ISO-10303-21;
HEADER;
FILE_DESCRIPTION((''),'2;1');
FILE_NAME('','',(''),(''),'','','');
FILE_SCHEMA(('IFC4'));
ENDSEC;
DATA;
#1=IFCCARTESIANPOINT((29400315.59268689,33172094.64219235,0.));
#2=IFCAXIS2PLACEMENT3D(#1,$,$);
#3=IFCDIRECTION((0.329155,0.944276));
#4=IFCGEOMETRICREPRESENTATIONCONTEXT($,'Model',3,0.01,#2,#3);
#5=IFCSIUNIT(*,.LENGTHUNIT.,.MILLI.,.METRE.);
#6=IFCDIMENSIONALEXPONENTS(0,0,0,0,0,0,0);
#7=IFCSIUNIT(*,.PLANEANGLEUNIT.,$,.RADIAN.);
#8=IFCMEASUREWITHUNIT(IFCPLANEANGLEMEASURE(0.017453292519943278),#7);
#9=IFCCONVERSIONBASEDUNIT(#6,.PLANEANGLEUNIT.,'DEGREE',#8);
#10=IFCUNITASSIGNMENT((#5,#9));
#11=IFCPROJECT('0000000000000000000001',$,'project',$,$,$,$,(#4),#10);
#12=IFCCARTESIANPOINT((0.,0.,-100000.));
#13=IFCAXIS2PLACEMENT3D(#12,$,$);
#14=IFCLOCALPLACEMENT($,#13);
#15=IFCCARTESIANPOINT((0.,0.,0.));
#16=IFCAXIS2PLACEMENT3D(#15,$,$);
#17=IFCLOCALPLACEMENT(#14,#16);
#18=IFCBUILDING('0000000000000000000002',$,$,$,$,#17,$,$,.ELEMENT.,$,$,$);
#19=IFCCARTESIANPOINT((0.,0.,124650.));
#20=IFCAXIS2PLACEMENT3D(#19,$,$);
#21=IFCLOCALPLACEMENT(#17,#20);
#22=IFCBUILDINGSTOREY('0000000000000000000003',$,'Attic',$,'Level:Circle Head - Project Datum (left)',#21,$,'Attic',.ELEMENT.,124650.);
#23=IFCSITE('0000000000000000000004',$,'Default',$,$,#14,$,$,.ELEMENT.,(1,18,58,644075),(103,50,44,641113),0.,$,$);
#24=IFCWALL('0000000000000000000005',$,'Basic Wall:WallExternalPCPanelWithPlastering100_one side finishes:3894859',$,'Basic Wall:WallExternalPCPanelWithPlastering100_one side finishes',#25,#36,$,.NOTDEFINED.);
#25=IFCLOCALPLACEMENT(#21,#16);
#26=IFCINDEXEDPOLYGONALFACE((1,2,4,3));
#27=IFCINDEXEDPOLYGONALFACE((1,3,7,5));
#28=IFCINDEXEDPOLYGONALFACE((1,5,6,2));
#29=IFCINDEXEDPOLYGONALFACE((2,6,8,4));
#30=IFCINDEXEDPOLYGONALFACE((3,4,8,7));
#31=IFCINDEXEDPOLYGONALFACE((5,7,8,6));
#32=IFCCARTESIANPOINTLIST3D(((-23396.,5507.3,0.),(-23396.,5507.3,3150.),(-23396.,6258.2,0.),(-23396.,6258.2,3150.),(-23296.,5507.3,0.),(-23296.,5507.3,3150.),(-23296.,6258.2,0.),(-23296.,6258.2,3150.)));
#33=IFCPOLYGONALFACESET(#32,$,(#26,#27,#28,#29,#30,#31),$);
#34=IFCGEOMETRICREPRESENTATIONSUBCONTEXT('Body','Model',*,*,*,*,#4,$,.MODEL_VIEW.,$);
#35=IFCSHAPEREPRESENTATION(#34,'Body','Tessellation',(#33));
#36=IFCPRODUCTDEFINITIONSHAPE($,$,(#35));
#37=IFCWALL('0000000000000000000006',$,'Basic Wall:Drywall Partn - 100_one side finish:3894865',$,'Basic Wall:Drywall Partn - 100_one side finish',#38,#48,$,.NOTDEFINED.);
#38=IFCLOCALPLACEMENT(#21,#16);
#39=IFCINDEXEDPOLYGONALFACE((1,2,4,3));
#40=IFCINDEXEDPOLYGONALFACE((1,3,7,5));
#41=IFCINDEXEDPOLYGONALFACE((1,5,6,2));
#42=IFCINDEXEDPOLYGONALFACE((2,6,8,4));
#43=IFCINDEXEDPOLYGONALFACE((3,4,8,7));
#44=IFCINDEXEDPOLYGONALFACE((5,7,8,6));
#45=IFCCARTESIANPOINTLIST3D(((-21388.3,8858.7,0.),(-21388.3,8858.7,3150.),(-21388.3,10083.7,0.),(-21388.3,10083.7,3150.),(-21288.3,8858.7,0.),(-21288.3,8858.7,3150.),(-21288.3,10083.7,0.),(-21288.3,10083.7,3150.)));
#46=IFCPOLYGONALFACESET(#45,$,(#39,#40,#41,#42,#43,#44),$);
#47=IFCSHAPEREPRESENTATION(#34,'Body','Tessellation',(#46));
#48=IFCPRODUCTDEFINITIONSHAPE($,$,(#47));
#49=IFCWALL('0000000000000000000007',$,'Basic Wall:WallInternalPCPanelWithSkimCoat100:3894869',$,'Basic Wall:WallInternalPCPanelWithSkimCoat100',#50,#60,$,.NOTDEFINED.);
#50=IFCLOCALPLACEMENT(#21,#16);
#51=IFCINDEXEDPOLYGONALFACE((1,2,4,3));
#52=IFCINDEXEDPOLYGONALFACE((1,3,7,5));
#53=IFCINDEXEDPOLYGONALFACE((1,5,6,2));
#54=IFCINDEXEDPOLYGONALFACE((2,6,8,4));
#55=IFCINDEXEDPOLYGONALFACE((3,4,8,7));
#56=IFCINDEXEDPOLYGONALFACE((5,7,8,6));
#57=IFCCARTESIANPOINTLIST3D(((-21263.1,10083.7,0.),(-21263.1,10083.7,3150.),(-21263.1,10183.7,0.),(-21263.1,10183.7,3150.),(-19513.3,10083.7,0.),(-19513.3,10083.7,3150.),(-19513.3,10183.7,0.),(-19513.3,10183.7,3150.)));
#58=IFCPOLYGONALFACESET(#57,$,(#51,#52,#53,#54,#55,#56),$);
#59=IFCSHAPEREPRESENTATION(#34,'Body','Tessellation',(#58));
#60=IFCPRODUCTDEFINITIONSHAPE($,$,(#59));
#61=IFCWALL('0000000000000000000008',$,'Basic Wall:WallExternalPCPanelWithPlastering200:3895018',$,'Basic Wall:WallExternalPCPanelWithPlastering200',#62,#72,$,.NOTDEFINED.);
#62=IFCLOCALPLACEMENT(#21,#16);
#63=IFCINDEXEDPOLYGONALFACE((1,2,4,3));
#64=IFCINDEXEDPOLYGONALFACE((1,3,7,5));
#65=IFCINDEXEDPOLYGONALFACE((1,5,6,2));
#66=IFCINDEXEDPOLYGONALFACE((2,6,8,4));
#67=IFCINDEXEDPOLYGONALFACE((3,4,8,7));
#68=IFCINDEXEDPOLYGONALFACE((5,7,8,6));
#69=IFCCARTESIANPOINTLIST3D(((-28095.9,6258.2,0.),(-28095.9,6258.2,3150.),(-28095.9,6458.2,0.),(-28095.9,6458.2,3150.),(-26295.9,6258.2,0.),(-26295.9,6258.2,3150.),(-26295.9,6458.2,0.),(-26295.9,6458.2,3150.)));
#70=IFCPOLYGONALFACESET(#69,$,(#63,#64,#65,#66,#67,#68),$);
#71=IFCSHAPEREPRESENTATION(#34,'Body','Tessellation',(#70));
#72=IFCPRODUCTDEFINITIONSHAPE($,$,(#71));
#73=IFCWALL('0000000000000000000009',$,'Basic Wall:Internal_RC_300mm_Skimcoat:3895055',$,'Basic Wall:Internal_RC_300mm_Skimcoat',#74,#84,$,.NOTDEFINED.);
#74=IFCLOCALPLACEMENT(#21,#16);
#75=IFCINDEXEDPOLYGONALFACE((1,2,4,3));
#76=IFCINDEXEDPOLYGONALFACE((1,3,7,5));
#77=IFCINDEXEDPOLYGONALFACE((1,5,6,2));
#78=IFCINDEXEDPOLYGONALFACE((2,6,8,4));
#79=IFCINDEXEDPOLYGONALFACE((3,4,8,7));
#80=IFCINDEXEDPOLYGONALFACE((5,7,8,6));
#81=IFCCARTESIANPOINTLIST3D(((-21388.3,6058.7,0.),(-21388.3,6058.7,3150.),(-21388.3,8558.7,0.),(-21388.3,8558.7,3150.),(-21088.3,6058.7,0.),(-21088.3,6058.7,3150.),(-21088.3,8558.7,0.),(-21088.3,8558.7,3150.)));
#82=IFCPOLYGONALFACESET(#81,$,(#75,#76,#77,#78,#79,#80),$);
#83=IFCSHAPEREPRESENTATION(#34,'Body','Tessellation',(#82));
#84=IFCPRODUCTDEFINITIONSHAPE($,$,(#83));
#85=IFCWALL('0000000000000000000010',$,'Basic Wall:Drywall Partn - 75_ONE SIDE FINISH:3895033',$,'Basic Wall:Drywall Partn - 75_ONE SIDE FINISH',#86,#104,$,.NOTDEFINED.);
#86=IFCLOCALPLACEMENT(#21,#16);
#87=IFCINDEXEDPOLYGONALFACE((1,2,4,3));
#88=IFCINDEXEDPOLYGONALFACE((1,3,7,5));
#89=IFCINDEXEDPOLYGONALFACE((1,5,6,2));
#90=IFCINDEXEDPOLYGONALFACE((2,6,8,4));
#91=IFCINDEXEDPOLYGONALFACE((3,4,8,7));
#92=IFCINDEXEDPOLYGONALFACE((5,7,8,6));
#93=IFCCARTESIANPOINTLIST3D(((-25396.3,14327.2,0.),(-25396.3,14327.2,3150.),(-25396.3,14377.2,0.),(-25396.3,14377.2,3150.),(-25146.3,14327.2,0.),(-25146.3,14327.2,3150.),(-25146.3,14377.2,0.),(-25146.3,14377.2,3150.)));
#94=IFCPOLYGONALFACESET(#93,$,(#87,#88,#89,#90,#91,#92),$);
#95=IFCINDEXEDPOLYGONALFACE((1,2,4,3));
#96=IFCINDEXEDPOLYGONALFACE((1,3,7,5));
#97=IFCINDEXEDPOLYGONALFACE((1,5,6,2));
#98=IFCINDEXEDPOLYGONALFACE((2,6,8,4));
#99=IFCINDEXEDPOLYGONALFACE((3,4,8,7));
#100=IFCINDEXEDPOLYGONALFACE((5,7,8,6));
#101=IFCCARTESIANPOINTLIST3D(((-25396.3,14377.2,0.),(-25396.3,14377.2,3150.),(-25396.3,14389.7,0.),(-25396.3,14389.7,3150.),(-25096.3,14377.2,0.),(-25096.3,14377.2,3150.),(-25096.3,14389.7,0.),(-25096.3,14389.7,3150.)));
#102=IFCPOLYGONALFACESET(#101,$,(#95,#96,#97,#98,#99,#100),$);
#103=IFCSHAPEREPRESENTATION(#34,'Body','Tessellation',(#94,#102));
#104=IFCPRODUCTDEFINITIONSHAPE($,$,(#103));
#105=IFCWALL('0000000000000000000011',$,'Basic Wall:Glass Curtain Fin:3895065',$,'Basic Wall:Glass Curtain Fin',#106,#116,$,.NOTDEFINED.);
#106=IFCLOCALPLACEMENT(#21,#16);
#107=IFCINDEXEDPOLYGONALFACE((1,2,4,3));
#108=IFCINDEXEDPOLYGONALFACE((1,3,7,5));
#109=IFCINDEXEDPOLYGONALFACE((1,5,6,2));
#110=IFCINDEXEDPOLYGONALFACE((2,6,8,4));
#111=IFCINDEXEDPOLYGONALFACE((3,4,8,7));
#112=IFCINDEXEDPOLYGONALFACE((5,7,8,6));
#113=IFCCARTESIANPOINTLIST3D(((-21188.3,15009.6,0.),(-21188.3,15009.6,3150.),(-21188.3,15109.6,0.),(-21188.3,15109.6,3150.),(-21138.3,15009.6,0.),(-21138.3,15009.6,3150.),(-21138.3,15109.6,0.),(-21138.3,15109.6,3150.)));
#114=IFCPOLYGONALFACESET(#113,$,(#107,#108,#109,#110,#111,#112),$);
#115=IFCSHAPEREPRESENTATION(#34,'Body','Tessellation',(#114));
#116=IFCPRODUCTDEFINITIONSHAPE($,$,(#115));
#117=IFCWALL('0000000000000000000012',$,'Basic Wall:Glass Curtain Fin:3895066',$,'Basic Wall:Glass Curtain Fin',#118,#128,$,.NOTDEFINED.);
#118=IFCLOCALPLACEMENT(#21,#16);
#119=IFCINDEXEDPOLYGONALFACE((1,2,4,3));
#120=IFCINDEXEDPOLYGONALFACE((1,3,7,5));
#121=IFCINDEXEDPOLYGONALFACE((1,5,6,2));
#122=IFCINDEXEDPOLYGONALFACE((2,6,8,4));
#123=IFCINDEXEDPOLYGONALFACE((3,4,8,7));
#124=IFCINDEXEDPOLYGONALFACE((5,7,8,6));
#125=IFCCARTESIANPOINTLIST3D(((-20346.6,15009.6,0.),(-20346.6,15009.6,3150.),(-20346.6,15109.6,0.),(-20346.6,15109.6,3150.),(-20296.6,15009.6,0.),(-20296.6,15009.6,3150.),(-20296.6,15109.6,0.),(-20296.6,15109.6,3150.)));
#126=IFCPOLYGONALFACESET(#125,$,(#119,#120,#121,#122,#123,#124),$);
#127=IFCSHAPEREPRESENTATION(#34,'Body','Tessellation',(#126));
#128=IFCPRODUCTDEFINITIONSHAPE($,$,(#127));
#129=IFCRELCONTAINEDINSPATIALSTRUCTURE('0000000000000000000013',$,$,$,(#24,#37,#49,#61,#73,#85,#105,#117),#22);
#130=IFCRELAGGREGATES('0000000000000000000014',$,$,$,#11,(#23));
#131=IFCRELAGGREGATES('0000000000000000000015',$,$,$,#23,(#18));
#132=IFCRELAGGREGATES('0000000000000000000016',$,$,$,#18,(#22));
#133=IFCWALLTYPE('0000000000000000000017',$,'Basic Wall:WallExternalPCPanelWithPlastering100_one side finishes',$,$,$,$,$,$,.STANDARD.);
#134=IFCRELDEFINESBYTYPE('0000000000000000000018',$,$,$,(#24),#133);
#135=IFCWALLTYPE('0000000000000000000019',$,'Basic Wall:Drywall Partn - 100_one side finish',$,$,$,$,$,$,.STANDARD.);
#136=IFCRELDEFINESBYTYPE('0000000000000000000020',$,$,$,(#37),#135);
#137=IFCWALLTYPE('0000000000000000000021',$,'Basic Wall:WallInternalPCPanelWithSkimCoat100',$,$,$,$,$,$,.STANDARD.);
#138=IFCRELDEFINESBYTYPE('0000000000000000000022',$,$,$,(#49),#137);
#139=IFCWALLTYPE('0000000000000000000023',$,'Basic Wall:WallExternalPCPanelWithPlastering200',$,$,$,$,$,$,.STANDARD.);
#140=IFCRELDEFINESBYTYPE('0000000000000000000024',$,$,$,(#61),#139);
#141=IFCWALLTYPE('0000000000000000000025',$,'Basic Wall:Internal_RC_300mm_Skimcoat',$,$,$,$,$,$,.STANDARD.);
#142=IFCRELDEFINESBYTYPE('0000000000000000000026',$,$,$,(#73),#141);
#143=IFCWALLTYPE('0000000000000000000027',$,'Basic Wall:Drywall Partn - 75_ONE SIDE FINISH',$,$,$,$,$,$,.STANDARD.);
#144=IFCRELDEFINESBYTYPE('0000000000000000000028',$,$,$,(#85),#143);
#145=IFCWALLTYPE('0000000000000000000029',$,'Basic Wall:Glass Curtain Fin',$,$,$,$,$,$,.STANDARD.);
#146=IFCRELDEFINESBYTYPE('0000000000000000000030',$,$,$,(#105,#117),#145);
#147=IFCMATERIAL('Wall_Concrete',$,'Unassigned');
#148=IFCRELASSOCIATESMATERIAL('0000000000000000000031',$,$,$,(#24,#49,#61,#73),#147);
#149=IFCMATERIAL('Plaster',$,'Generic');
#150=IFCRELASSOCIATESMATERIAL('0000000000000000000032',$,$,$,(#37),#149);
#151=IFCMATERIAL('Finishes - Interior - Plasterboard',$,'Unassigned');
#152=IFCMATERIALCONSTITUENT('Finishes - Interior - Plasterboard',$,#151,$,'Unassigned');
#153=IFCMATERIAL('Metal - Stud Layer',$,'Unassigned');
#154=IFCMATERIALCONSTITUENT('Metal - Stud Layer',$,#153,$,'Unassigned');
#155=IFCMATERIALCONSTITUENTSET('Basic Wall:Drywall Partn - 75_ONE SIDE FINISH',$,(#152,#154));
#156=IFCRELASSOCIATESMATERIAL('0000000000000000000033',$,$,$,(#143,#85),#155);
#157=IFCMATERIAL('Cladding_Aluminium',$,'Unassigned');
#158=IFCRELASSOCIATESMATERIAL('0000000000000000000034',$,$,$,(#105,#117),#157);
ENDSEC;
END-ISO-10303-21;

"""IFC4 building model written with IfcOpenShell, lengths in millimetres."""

from ifc_helpers import new_model, entity, si_unit, converted_unit, direction, frame, origin, place, context, subcontext, project, spatial, indexed_curve, outline, extrude, material, constituent, constituent_set, type_object, element, save


model = new_model("IFC4")

# Units and contexts
model_context = context("Model", 3, precision=0.01, world=frame((29400315.59268689, 33172094.64219235, 0.0)), true_north=direction((0.329155, 0.944276)))
body_context = subcontext(model_context, "Body", "Model", "MODEL_VIEW")
ifc_project = project(units=[si_unit("LENGTHUNIT", "METRE", prefix="MILLI"), converted_unit("PLANEANGLEUNIT", "DEGREE", entity("IfcPlaneAngleMeasure", 0.017453292519943278), si_unit("PLANEANGLEUNIT", "RADIAN"), dimensions=[0, 0, 0, 0, 0, 0, 0])], contexts=[model_context])

# Site, building, storey
site_placement = place(None, frame((0.0, 0.0, -100000.0)))
site = spatial("IfcSite", under=ifc_project, at=site_placement, Name="Default", CompositionType="ELEMENT", RefLatitude=(1, 18, 58, 644075), RefLongitude=(103, 50, 44, 641113), RefElevation=0.0)
building_placement = place(site_placement, origin())
building = spatial("IfcBuilding", under=site, at=building_placement, CompositionType="ELEMENT")
storey_placement = place(building_placement, frame((0.0, 0.0, 124650.0)))
storey = spatial("IfcBuildingStorey", under=building, at=storey_placement, Name="Attic", ObjectType="Level:Circle Head - Project Datum (left)", LongName="Attic", CompositionType="ELEMENT", Elevation=124650.0)

# Walls
ifc_material_1 = material(Name="Metal - Stud Layer", Category="Unassigned")
ifc_material_2 = material(Name="Wall_Concrete", Category="Unassigned")
wall_type_1 = type_object("IfcWallType", Name="Basic Wall:WallExternalPCPanelWithPlastering100_one side finishes", PredefinedType="STANDARD")
wall_1_placement = place(storey_placement, frame((-23346.0, 6258.2, 0.0), z_axis=(0.0, 0.0, 1.0), x_axis=(0.0, -1.0, 0.0)))
element("IfcWall", 1, at=wall_1_placement, inside=storey, type_object=wall_type_1, material=ifc_material_2, Name="Basic Wall:WallExternalPCPanelWithPlastering100_one side finishes:3894859", ObjectType="Basic Wall:WallExternalPCPanelWithPlastering100_one side finishes", PredefinedType="NOTDEFINED", context=body_context, shape_type="SweptSolid", body=[
    extrude(outline(indexed_curve([(751.0, 50.0), (0.0, 50.0), (0.0, -50.0), (751.0, -50.0), (751.0, 50.0)], self_intersect=False)), origin(), (0.0, 0.0, 1.0), 3150.0),
])
ifc_material_3 = material(Name="Plaster", Category="Generic")
wall_type_2 = type_object("IfcWallType", Name="Basic Wall:Drywall Partn - 100_one side finish", PredefinedType="STANDARD")
wall_2_placement = place(storey_placement, frame((-21338.3, 8858.7, 0.0), z_axis=(0.0, 0.0, 1.0), x_axis=(0.0, 1.0, 0.0)))
element("IfcWall", 2, at=wall_2_placement, inside=storey, type_object=wall_type_2, material=ifc_material_3, Name="Basic Wall:Drywall Partn - 100_one side finish:3894865", ObjectType="Basic Wall:Drywall Partn - 100_one side finish", PredefinedType="NOTDEFINED", context=body_context, shape_type="SweptSolid", body=[
    extrude(outline(indexed_curve([(1225.0, 50.0), (0.0, 50.0), (0.0, -50.0), (1225.0, -50.0), (1225.0, 50.0)], self_intersect=False)), origin(), (0.0, 0.0, 1.0), 3150.0),
])
wall_type_3 = type_object("IfcWallType", Name="Basic Wall:WallInternalPCPanelWithSkimCoat100", PredefinedType="STANDARD")
wall_3_placement = place(storey_placement, frame((-19513.3, 10133.7, 0.0), z_axis=(0.0, 0.0, 1.0), x_axis=(-1.0, 0.0, 0.0)))
element("IfcWall", 3, at=wall_3_placement, inside=storey, type_object=wall_type_3, material=ifc_material_2, Name="Basic Wall:WallInternalPCPanelWithSkimCoat100:3894869", ObjectType="Basic Wall:WallInternalPCPanelWithSkimCoat100", PredefinedType="NOTDEFINED", context=body_context, shape_type="SweptSolid", body=[
    extrude(outline(indexed_curve([(1749.7, 50.0), (0.0, 50.0), (0.0, -50.0), (1749.7, -50.0), (1749.7, 50.0)], self_intersect=False)), origin(), (0.0, 0.0, 1.0), 3150.0),
])
wall_type_4 = type_object("IfcWallType", Name="Basic Wall:WallExternalPCPanelWithPlastering200", PredefinedType="STANDARD")
wall_4_placement = place(storey_placement, frame((-26295.9, 6358.2, 0.0), z_axis=(0.0, 0.0, 1.0), x_axis=(-1.0, 0.0, 0.0)))
element("IfcWall", 4, at=wall_4_placement, inside=storey, type_object=wall_type_4, material=ifc_material_2, Name="Basic Wall:WallExternalPCPanelWithPlastering200:3895018", ObjectType="Basic Wall:WallExternalPCPanelWithPlastering200", PredefinedType="NOTDEFINED", context=body_context, shape_type="SweptSolid", body=[
    extrude(outline(indexed_curve([(1800.0, 100.0), (0.0, 100.0), (0.0, -100.0), (1800.0, -100.0), (1800.0, 100.0)], self_intersect=False)), origin(), (0.0, 0.0, 1.0), 3150.0),
])
wall_type_5 = type_object("IfcWallType", Name="Basic Wall:Internal_RC_300mm_Skimcoat", PredefinedType="STANDARD")
wall_5_placement = place(storey_placement, frame((-21238.3, 8558.7, 0.0), z_axis=(0.0, 0.0, 1.0), x_axis=(0.0, -1.0, 0.0)))
element("IfcWall", 5, at=wall_5_placement, inside=storey, type_object=wall_type_5, material=ifc_material_2, Name="Basic Wall:Internal_RC_300mm_Skimcoat:3895055", ObjectType="Basic Wall:Internal_RC_300mm_Skimcoat", PredefinedType="NOTDEFINED", context=body_context, shape_type="SweptSolid", body=[
    extrude(outline(indexed_curve([(2500.0, 150.0), (0.0, 150.0), (0.0, -150.0), (2500.0, -150.0), (2500.0, 150.0)], self_intersect=False)), origin(), (0.0, 0.0, 1.0), 3150.0),
])
ifc_material_4 = material(Name="Finishes - Interior - Plasterboard", Category="Unassigned")
ifc_constituent_1 = constituent(ifc_material_4, Name="Finishes - Interior - Plasterboard", Category="Unassigned")
ifc_constituent_2 = constituent(ifc_material_1, Name="Metal - Stud Layer", Category="Unassigned")
ifc_constituent_set = constituent_set(constituents=[ifc_constituent_1, ifc_constituent_2], Name="Basic Wall:Drywall Partn - 75_ONE SIDE FINISH")
wall_type_6 = type_object("IfcWallType", Name="Basic Wall:Drywall Partn - 75_ONE SIDE FINISH", PredefinedType="STANDARD", material=ifc_constituent_set)
wall_6_placement = place(storey_placement, frame((-25146.3, 14358.4, 0.0), z_axis=(0.0, 0.0, 1.0), x_axis=(-1.0, 0.0, 0.0)))
element("IfcWall", 6, at=wall_6_placement, inside=storey, type_object=wall_type_6, material=ifc_constituent_set, Name="Basic Wall:Drywall Partn - 75_ONE SIDE FINISH:3895033", ObjectType="Basic Wall:Drywall Partn - 75_ONE SIDE FINISH", PredefinedType="NOTDEFINED", context=body_context, shape_type="SweptSolid", body=[
    extrude(outline(indexed_curve([(-25.0, -125.0), (25.0, -125.0), (25.0, 125.0), (-25.0, 125.0), (-25.0, -125.0)], self_intersect=False)), frame((125.0, 6.3, 0.0), z_axis=(0.0, 0.0, 1.0), x_axis=(0.0, -1.0, 0.0)), (0.0, 0.0, 1.0), 3150.0),
    extrude(outline(indexed_curve([(-6.3, -150.0), (6.3, -150.0), (6.3, 150.0), (-6.3, 150.0), (-6.3, -150.0)], self_intersect=False)), frame((100.0, -25.0, 0.0), z_axis=(0.0, 0.0, 1.0), x_axis=(0.0, 1.0, 0.0)), (0.0, 0.0, 1.0), 3150.0),
])
ifc_material_5 = material(Name="Cladding_Aluminium", Category="Unassigned")
wall_type_7 = type_object("IfcWallType", Name="Basic Wall:Glass Curtain Fin", PredefinedType="STANDARD")
for number, where, z_axis, x_axis, name in (
    (7, (-21163.3, 15009.6, 0.0), (0.0, 0.0, 1.0), (0.0, 1.0, 0.0), "Basic Wall:Glass Curtain Fin:3895065"),
    (8, (-20321.6, 15009.6, 0.0), (0.0, 0.0, 1.0), (0.0, 1.0, 0.0), "Basic Wall:Glass Curtain Fin:3895066"),
):
    element("IfcWall", number, at=place(storey_placement, frame(where, z_axis=z_axis, x_axis=x_axis)), inside=storey, type_object=wall_type_7, material=ifc_material_5, Name=name, ObjectType="Basic Wall:Glass Curtain Fin", PredefinedType="NOTDEFINED", context=body_context, shape_type="SweptSolid", body=[
        extrude(outline(indexed_curve([(100.0, 25.0), (0.0, 25.0), (0.0, -25.0), (100.0, -25.0), (100.0, 25.0)], self_intersect=False)), origin(), (0.0, 0.0, 1.0), 3150.0),
    ])

save(model, "model.ifc")
